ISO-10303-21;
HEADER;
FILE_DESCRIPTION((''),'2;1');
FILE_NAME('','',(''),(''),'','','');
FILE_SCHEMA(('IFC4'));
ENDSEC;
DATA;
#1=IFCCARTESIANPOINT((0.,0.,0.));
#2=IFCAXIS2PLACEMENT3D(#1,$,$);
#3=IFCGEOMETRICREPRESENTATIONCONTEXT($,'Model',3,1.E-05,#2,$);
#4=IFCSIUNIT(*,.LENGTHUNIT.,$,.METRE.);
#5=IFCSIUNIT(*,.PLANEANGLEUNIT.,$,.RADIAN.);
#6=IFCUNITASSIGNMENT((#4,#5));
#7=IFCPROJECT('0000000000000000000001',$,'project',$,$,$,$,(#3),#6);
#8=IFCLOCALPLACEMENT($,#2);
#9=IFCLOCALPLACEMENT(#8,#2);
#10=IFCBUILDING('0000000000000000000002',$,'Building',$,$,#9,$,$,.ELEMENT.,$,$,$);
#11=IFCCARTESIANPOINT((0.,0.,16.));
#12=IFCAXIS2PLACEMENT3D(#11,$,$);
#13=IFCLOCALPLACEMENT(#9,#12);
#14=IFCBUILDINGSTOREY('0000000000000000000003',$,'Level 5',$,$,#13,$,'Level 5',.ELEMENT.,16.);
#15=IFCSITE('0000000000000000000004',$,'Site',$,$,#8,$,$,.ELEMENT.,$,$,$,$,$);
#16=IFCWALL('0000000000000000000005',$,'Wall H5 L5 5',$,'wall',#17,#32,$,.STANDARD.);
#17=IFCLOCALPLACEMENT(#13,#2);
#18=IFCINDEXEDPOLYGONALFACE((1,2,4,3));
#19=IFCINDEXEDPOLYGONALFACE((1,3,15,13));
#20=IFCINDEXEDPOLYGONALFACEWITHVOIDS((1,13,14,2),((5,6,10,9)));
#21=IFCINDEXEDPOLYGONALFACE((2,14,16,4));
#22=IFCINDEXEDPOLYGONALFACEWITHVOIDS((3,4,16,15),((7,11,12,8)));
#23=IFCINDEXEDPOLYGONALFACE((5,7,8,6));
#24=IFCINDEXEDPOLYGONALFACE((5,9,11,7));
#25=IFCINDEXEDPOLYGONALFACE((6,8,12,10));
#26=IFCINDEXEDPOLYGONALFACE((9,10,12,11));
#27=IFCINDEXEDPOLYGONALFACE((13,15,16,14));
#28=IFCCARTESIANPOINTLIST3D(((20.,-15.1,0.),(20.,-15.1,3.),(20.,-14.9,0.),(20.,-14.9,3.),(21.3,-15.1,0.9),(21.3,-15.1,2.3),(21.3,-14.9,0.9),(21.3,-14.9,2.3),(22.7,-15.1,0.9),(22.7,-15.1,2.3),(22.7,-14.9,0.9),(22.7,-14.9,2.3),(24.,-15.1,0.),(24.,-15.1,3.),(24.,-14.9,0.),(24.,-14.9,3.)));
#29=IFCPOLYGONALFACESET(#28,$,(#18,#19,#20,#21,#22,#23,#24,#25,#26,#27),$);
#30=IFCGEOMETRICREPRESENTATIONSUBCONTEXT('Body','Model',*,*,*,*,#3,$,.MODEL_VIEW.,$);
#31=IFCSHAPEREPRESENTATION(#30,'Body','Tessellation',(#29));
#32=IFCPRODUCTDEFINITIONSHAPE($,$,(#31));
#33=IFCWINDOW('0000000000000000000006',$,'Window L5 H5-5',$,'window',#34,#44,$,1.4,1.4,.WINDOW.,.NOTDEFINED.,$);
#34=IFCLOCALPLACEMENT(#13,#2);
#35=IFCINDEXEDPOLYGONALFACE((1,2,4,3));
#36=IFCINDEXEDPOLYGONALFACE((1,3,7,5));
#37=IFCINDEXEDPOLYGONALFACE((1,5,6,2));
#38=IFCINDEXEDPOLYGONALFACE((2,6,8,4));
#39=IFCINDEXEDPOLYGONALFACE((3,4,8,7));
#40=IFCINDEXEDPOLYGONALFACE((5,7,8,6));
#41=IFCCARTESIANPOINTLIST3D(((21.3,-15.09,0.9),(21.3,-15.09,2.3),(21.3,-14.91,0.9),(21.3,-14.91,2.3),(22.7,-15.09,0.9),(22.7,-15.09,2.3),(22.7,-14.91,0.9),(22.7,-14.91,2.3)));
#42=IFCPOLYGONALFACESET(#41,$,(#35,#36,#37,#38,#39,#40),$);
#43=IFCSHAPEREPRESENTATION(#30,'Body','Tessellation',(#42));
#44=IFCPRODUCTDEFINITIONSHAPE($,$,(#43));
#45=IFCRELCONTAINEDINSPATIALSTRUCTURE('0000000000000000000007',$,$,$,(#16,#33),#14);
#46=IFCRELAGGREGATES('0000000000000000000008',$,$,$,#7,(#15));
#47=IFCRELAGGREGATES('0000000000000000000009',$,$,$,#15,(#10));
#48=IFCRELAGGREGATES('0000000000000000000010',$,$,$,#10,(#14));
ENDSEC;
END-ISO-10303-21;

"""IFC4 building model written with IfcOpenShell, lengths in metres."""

from ifc_helpers import new_model, si_unit, frame, frame_2d, origin, origin_2d, place, context, subcontext, project, spatial, rectangle, extrude, element, fill, save


model = new_model("IFC4")

# Units and contexts
model_context = context("Model", 3, precision=1e-05, world=origin())
body_context = subcontext(model_context, "Body", "Model", "MODEL_VIEW")
ifc_project = project(units=[si_unit("LENGTHUNIT", "METRE"), si_unit("PLANEANGLEUNIT", "RADIAN")], contexts=[model_context])

# Site, building, storey
site_placement = place(None, origin())
site = spatial("IfcSite", under=ifc_project, at=site_placement, Name="Site", CompositionType="ELEMENT")
building_placement = place(site_placement, origin())
building = spatial("IfcBuilding", under=site, at=building_placement, Name="Building", CompositionType="ELEMENT")
storey_placement = place(building_placement, frame((0.0, 0.0, 16.0)))
storey = spatial("IfcBuildingStorey", under=building, at=storey_placement, Name="Level 5", LongName="Level 5", CompositionType="ELEMENT", Elevation=16.0)

# Wall, opening, window
wall_1_placement = place(storey_placement, frame((20.0, -15.0, 0.0), z_axis=(0.0, 0.0, 1.0), x_axis=(1.0, 0.0, 0.0)))
wall_1 = element("IfcWall", 1, at=wall_1_placement, inside=storey, Name="Wall H5 L5 5", ObjectType="wall", PredefinedType="STANDARD", context=body_context, shape_type="SweptSolid", body=[
    extrude(rectangle(XDim=4.0, YDim=0.2, at=frame_2d((2.0, 0.0))), origin(), (0.0, 0.0, 1.0), 3.0),
])
opening_1_placement = place(storey_placement, frame((22.0, -15.0, 0.9), z_axis=(0.0, 0.0, 1.0), x_axis=(1.0, 0.0, 0.0)))
opening_1 = element("IfcOpeningElement", 2, at=opening_1_placement, cuts=wall_1, ObjectType="Opening", PredefinedType="OPENING", context=body_context, shape_type="SweptSolid", body=[
    extrude(rectangle(XDim=1.4, YDim=0.22, at=origin_2d()), origin(), (0.0, 0.0, 1.0), 1.4),
])
window_1_placement = place(storey_placement, frame((22.0, -15.0, 0.9), z_axis=(0.0, 0.0, 1.0), x_axis=(1.0, 0.0, 0.0)))
window_1 = element("IfcWindow", 3, at=window_1_placement, inside=storey, Name="Window L5 H5-5", ObjectType="window", OverallHeight=1.4, OverallWidth=1.4, PartitioningType="NOTDEFINED", PredefinedType="WINDOW", context=body_context, shape_type="SweptSolid", body=[
    extrude(rectangle(XDim=1.4, YDim=0.18, at=origin_2d()), origin(), (0.0, 0.0, 1.0), 1.4),
])
fill(opening_1, window_1)

save(model, "model.ifc")
